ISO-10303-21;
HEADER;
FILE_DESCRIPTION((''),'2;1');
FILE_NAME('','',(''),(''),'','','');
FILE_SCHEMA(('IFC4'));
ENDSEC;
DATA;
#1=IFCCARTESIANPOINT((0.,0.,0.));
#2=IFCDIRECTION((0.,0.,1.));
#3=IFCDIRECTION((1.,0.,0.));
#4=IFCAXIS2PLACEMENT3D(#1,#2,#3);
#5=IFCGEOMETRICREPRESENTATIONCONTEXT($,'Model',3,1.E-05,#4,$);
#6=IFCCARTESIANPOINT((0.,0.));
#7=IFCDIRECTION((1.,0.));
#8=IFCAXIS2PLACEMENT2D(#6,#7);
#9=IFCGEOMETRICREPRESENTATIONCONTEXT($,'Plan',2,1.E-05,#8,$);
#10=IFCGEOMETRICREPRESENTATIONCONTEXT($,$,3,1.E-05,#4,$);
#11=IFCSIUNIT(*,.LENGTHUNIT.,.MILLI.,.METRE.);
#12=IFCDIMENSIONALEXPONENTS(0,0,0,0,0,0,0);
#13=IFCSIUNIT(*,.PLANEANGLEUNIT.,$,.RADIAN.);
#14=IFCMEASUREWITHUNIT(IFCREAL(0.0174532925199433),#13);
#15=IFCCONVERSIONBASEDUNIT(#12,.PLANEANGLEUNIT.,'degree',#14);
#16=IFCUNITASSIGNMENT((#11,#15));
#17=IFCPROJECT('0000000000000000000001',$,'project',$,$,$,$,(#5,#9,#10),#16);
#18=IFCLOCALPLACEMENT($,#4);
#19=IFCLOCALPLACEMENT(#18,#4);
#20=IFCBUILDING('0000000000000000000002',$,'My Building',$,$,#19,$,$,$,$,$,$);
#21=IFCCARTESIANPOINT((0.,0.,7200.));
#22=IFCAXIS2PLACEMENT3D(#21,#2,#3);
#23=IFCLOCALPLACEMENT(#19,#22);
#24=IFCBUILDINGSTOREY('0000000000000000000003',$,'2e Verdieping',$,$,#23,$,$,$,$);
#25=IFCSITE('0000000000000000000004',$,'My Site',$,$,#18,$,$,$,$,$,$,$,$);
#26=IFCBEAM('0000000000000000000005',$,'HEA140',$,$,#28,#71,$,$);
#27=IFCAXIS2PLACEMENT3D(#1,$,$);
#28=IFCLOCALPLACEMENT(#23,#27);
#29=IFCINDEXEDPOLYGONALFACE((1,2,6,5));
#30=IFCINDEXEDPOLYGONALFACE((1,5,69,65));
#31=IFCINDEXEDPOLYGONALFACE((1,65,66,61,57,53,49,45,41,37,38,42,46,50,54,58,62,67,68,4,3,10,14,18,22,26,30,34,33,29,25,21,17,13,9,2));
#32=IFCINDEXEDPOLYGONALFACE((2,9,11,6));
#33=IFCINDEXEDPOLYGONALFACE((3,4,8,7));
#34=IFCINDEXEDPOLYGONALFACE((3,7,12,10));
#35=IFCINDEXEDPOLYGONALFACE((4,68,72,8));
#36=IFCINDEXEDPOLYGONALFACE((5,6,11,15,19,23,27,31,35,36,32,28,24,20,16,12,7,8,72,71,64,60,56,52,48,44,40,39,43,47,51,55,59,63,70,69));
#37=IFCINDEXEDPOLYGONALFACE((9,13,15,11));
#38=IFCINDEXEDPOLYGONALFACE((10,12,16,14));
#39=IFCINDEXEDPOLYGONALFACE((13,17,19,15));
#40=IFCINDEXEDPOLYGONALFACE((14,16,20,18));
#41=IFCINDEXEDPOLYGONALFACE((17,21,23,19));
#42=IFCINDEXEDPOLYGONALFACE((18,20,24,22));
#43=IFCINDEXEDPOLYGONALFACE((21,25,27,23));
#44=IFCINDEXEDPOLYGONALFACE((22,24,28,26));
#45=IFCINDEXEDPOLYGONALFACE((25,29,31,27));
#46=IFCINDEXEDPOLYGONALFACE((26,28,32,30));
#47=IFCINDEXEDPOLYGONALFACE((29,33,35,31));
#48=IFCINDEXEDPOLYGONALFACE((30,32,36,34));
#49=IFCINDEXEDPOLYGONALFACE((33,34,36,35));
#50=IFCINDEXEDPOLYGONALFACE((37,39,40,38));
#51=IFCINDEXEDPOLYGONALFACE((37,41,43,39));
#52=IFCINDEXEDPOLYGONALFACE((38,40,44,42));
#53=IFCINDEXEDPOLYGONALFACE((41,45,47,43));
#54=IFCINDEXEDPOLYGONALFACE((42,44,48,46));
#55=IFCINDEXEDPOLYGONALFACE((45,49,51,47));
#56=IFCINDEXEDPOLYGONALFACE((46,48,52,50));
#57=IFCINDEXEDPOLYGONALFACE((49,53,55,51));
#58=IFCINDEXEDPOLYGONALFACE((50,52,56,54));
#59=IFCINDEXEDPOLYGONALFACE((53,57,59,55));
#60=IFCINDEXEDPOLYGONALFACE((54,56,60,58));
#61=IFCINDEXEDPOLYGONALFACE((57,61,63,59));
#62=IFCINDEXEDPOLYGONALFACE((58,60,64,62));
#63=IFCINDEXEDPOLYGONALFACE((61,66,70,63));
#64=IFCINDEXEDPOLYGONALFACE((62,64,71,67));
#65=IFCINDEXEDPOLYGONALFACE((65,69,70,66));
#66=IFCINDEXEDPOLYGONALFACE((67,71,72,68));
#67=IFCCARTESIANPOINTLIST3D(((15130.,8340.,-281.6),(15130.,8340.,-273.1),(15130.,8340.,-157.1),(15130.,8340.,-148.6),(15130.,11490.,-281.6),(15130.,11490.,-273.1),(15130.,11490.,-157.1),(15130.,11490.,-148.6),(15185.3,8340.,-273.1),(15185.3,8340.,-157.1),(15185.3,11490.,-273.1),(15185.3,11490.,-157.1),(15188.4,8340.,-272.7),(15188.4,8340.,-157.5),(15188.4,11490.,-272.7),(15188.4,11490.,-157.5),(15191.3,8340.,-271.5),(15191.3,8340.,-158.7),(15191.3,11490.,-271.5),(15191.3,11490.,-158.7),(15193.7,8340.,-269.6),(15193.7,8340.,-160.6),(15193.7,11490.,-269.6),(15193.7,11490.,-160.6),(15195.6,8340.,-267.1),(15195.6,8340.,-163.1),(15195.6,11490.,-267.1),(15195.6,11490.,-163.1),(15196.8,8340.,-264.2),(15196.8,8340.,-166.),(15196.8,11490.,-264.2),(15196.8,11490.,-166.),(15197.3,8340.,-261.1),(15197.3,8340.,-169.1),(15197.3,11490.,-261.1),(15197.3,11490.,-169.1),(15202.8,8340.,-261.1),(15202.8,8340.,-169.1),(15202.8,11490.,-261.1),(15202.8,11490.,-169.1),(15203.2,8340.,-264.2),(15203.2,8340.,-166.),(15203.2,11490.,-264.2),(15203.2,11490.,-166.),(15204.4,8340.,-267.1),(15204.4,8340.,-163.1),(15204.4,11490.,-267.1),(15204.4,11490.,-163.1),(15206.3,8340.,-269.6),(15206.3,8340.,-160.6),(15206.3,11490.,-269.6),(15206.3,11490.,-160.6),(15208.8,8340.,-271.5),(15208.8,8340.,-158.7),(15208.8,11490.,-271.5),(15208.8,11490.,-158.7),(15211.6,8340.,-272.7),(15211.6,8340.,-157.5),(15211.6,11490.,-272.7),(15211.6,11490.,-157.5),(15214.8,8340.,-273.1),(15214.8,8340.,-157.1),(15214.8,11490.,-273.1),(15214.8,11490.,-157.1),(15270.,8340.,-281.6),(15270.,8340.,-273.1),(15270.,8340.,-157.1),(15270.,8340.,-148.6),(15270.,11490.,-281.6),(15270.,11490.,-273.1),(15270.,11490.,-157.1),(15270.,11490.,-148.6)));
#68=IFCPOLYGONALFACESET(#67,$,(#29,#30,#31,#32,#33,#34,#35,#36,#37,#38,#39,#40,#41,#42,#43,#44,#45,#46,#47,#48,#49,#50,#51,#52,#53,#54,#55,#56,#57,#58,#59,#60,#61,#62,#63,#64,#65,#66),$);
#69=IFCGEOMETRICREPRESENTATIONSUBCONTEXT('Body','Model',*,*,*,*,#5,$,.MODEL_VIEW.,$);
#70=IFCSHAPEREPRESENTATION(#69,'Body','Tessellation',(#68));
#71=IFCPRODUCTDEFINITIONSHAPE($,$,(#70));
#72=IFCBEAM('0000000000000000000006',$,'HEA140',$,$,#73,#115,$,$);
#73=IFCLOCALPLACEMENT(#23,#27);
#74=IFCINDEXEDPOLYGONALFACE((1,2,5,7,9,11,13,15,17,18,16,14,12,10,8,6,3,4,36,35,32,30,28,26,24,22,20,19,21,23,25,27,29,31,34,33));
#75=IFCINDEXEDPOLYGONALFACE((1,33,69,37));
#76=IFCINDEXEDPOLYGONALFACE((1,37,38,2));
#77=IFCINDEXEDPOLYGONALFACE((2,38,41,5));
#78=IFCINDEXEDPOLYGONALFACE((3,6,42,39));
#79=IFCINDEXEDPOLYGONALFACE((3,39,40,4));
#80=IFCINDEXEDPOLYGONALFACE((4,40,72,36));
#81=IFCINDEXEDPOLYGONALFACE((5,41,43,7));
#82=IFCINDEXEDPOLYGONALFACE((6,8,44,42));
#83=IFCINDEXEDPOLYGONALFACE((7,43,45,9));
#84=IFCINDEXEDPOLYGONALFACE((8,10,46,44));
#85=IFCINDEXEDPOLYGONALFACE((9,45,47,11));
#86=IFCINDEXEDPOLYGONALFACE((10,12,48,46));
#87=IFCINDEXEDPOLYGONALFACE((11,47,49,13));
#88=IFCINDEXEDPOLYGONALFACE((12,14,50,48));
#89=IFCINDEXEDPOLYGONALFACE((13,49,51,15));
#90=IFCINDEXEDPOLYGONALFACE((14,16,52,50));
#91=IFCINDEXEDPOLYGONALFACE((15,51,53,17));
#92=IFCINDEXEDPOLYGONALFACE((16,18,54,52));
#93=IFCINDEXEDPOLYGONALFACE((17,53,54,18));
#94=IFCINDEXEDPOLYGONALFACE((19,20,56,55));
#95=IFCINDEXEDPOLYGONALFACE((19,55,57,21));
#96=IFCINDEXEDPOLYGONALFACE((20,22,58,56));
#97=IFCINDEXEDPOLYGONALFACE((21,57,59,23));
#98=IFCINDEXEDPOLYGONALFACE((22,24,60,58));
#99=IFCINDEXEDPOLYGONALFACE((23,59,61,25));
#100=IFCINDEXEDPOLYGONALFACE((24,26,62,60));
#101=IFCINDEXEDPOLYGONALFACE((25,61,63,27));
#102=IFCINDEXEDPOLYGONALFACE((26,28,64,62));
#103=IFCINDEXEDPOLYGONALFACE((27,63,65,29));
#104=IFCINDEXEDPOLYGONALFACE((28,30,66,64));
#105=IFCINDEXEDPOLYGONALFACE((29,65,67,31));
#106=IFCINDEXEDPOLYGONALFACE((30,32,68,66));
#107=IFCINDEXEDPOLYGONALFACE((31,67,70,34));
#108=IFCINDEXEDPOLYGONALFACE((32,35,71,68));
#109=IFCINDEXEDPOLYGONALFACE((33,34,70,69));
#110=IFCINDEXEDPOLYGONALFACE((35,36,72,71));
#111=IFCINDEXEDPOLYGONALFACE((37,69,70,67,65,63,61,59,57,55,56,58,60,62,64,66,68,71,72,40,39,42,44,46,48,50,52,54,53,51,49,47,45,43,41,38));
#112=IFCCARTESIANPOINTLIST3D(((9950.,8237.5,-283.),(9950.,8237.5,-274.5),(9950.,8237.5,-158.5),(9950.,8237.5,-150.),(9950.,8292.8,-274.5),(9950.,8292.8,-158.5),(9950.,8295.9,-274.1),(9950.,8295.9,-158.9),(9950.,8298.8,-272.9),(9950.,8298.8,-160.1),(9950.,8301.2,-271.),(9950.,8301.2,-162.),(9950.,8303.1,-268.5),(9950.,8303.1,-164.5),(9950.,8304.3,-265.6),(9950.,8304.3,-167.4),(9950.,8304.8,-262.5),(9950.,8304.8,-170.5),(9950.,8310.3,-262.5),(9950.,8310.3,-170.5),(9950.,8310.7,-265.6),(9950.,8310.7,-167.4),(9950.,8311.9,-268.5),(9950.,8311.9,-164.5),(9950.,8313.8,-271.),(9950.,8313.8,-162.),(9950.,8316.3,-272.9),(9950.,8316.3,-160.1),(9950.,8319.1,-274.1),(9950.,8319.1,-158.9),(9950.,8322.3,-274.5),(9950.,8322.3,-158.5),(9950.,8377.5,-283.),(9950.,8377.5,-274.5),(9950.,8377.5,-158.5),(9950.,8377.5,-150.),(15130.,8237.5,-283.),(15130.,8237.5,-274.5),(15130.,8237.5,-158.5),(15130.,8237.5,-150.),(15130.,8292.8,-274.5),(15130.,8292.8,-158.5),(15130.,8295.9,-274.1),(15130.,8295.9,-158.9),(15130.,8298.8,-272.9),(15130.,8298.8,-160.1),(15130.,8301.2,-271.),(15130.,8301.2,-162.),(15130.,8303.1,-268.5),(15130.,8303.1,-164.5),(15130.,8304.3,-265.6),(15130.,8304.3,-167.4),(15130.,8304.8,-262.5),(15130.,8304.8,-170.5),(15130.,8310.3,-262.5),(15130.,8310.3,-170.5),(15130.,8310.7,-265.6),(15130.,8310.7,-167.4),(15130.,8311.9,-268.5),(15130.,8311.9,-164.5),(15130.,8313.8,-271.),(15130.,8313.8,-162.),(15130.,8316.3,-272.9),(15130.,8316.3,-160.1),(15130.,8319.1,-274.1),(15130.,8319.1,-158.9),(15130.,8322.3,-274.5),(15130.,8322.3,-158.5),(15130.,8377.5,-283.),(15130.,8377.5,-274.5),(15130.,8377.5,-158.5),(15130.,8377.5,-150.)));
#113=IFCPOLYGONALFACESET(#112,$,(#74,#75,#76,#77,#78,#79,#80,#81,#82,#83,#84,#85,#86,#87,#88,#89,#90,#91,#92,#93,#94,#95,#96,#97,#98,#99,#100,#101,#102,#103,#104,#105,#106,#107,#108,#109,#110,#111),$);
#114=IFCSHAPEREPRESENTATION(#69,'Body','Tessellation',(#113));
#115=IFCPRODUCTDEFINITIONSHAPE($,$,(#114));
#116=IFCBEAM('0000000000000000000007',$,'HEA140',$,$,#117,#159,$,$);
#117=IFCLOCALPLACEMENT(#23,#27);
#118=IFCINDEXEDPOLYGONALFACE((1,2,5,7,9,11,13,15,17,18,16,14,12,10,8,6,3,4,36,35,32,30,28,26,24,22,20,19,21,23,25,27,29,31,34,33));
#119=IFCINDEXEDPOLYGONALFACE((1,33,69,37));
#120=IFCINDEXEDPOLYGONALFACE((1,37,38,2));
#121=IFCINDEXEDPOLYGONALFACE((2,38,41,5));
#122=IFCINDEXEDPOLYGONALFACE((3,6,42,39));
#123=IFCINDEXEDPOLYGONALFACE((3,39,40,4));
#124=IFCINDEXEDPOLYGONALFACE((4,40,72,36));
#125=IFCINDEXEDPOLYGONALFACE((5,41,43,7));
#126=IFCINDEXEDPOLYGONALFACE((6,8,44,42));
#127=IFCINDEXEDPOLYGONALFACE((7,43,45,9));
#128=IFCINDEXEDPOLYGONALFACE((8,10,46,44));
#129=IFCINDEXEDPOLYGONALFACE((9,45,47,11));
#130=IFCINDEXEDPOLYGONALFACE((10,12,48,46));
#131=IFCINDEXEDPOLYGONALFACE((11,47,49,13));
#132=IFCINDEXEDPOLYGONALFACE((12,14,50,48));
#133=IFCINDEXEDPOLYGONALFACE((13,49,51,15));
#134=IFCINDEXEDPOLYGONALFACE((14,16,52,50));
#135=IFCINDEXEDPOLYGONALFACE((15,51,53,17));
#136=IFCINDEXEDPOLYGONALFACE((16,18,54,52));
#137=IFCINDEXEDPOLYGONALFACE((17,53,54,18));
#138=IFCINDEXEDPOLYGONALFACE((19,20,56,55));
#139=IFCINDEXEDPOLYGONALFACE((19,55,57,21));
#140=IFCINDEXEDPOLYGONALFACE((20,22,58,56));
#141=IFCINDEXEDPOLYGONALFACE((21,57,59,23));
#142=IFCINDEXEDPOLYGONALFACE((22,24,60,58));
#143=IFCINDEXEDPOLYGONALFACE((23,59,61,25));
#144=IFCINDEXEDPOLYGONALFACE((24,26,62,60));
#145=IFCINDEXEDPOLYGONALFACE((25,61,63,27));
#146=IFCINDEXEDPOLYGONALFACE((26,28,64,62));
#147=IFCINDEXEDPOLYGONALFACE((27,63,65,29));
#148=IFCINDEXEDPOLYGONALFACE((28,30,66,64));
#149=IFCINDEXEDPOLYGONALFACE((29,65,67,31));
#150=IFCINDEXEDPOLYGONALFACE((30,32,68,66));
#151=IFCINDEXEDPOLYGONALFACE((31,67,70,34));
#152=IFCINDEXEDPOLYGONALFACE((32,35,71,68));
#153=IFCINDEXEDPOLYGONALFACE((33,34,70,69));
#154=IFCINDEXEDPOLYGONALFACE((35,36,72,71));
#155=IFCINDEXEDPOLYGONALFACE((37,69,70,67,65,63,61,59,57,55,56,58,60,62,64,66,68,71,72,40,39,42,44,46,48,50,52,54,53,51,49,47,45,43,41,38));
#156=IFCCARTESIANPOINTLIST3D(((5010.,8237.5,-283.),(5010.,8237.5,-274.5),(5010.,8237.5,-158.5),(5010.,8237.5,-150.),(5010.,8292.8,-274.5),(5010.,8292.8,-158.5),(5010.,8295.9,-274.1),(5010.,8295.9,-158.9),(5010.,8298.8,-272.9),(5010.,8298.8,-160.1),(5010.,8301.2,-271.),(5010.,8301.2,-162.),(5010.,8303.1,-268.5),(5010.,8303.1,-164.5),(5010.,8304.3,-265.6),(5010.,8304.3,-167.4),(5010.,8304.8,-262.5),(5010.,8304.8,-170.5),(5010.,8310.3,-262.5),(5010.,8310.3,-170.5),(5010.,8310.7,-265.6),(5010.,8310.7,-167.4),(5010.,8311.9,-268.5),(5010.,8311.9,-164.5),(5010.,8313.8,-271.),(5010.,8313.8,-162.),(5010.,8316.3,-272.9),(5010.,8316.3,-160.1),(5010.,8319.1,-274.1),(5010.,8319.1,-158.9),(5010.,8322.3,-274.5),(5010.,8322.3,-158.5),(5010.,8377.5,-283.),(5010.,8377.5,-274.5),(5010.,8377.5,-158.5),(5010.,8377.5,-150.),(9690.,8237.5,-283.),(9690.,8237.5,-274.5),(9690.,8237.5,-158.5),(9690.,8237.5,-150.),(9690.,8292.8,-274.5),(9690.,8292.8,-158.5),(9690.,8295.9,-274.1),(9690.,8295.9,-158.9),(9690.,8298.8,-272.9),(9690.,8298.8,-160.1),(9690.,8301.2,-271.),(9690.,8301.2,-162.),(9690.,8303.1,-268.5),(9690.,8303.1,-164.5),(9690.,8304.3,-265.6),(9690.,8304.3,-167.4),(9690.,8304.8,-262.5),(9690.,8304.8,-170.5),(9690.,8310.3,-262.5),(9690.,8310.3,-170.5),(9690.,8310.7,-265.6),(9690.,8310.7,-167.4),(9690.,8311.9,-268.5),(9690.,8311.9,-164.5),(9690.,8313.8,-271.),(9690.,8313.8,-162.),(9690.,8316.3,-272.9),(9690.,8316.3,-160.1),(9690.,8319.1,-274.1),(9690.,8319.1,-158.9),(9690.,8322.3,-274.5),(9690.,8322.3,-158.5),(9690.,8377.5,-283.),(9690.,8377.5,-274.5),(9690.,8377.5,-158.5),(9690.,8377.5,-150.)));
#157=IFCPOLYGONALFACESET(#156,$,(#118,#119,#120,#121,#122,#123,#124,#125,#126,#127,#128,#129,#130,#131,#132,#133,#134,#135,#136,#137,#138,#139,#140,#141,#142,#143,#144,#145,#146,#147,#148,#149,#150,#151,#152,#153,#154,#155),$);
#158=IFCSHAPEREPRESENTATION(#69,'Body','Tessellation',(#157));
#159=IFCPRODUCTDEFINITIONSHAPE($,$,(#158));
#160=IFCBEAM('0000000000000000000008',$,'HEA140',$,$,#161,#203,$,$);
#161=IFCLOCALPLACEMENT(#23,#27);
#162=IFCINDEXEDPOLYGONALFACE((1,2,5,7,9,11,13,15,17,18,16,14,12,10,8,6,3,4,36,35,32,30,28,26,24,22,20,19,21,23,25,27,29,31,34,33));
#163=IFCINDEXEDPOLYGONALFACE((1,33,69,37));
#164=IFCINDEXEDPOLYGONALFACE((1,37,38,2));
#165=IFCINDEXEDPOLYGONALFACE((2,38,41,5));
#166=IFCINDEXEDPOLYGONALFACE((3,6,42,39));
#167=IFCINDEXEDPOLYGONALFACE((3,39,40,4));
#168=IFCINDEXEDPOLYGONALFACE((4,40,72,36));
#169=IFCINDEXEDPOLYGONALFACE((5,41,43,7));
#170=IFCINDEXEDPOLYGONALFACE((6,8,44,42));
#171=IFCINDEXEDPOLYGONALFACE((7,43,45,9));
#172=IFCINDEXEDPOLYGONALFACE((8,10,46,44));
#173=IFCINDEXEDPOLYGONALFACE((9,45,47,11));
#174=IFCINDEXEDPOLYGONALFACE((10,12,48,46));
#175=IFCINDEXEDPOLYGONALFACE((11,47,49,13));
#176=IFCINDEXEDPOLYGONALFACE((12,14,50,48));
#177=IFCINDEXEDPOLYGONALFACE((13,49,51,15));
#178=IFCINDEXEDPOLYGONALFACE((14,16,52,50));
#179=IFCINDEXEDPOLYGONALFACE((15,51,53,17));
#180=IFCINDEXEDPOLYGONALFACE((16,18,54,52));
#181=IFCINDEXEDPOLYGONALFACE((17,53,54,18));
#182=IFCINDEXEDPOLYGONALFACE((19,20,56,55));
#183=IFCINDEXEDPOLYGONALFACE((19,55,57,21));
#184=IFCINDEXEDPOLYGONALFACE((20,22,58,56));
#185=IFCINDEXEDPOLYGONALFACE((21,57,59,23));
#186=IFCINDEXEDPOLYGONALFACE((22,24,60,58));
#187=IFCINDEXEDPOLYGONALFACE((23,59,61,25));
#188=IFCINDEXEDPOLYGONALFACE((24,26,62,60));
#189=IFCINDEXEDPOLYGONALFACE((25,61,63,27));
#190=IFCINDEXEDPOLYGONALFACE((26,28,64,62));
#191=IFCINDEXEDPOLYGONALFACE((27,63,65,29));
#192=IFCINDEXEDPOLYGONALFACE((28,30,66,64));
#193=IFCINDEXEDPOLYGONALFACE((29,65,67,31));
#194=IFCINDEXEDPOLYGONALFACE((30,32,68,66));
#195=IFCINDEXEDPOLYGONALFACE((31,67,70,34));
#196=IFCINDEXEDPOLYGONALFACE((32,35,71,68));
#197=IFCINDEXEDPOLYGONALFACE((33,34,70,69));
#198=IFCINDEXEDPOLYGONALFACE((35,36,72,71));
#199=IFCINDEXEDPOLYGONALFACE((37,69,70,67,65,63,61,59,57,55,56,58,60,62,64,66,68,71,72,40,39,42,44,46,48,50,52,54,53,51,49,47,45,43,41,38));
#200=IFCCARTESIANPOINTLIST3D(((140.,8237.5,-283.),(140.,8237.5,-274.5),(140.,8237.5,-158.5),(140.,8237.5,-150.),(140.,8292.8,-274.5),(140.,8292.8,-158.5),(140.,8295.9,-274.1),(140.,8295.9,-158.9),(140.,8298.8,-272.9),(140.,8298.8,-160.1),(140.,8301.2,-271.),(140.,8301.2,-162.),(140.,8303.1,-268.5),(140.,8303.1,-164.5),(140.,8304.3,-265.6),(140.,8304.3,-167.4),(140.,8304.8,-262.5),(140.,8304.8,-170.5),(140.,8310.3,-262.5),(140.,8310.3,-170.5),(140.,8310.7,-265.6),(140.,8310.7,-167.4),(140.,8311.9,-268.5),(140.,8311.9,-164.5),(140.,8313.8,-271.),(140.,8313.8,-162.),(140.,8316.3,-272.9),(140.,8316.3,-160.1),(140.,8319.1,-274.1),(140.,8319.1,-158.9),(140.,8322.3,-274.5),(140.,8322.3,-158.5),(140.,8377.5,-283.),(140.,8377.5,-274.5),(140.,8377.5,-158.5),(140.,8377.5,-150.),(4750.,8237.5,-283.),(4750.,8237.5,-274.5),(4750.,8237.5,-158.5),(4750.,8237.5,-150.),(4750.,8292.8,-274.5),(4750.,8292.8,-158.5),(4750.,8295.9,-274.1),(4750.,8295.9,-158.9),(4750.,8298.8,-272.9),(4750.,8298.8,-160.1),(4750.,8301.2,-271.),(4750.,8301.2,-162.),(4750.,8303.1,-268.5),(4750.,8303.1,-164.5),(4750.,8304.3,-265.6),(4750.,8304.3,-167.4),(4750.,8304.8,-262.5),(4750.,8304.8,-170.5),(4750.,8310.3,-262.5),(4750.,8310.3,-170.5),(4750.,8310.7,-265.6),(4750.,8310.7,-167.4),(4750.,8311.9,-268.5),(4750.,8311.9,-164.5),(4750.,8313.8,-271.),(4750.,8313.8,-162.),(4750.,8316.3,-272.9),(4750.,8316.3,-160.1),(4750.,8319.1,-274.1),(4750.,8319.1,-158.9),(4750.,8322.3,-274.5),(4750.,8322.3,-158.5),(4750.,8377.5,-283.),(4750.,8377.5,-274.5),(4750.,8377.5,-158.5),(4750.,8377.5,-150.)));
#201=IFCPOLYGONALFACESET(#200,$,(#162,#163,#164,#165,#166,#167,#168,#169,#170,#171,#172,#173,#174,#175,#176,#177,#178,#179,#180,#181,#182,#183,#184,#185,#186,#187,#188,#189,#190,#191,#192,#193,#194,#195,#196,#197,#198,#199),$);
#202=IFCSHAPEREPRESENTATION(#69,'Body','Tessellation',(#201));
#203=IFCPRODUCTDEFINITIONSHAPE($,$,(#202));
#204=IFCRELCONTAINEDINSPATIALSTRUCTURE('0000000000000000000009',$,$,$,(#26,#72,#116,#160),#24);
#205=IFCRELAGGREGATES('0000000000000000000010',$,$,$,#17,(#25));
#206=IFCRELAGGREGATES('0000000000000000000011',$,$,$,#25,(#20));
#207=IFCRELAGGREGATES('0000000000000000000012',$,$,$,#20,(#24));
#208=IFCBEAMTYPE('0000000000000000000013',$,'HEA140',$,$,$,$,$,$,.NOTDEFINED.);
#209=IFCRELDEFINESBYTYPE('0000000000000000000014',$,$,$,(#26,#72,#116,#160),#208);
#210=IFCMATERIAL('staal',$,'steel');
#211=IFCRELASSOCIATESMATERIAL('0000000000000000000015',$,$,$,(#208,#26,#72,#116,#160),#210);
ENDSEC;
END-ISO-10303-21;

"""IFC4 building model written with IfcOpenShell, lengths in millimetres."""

from ifc_helpers import new_model, entity, si_unit, converted_unit, frame, origin_with_axes, origin_2d_with_axis, place, context, subcontext, project, spatial, i_section, extrude, material, material_profile, profile_set, profile_usage, type_object, element, save


model = new_model("IFC4")

# Units and contexts
model_context = context("Model", 3, precision=1e-05, world=origin_with_axes())
plan_context = context("Plan", 2, precision=1e-05, world=origin_2d_with_axis())
context_of_model = context(None, 3, precision=1e-05, world=origin_with_axes())
body_context = subcontext(model_context, "Body", "Model", "MODEL_VIEW")
ifc_project = project(units=[si_unit("LENGTHUNIT", "METRE", prefix="MILLI"), converted_unit("PLANEANGLEUNIT", "degree", entity("IfcReal", 0.0174532925199433), si_unit("PLANEANGLEUNIT", "RADIAN"), dimensions=[0, 0, 0, 0, 0, 0, 0])], contexts=[model_context, plan_context, context_of_model])

# Site, building, storey
site_placement = place(None, origin_with_axes())
site = spatial("IfcSite", under=ifc_project, at=site_placement, Name="My Site")
building_placement = place(site_placement, origin_with_axes())
building = spatial("IfcBuilding", under=site, at=building_placement, Name="My Building")
storey_placement = place(building_placement, frame((0.0, 0.0, 7200.0), z_axis=(0.0, 0.0, 1.0), x_axis=(1.0, 0.0, 0.0)))
storey = spatial("IfcBuildingStorey", under=building, at=storey_placement, Name="2e Verdieping")

# Beams
ifc_material_1 = material(Name="staal", Category="steel")
ifc_material_profile_1 = material_profile(ifc_material_1, i_section(OverallWidth=140.0, OverallDepth=133.0, WebThickness=5.5, FlangeThickness=8.5, FilletRadius=12.0))
ifc_profile_set_1 = profile_set([ifc_material_profile_1], Name="HEA140")
beam_type_1 = type_object("IfcBeamType", Name="HEA140", PredefinedType="NOTDEFINED", material=ifc_profile_set_1)
ifc_profile_usage_1 = profile_usage(ifc_profile_set_1)
beam_1_placement = place(storey_placement, frame((15200.0, 8340.0, -215.1), z_axis=(0.0, 1.0, 0.0), x_axis=(-1.0, 0.0, 0.0)))
element("IfcBeam", 1, at=beam_1_placement, inside=storey, type_object=beam_type_1, material=ifc_profile_usage_1, Name="HEA140", context=body_context, shape_type="SweptSolid", body=[
    extrude(i_section(OverallWidth=140.0, OverallDepth=133.0, WebThickness=5.5, FlangeThickness=8.5, FilletRadius=12.0), origin_with_axes(), (0.0, 0.0, 1.0), 3150.0),
])
ifc_profile_usage_2 = profile_usage(ifc_profile_set_1)
beam_2_placement = place(storey_placement, frame((15130.0, 8307.5, -216.5), z_axis=(-1.0, 0.0, 0.0), x_axis=(0.0, -1.0, 0.0)))
element("IfcBeam", 2, at=beam_2_placement, inside=storey, type_object=beam_type_1, material=ifc_profile_usage_2, Name="HEA140", context=body_context, shape_type="SweptSolid", body=[
    extrude(i_section(OverallWidth=140.0, OverallDepth=133.0, WebThickness=5.5, FlangeThickness=8.5, FilletRadius=12.0), origin_with_axes(), (0.0, 0.0, 1.0), 5180.0),
])
ifc_profile_usage_3 = profile_usage(ifc_profile_set_1)
beam_3_placement = place(storey_placement, frame((9690.0, 8307.5, -216.5), z_axis=(-1.0, 0.0, 0.0), x_axis=(0.0, -1.0, 0.0)))
element("IfcBeam", 3, at=beam_3_placement, inside=storey, type_object=beam_type_1, material=ifc_profile_usage_3, Name="HEA140", context=body_context, shape_type="SweptSolid", body=[
    extrude(i_section(OverallWidth=140.0, OverallDepth=133.0, WebThickness=5.5, FlangeThickness=8.5, FilletRadius=12.0), origin_with_axes(), (0.0, 0.0, 1.0), 4680.0),
])
ifc_profile_usage_4 = profile_usage(ifc_profile_set_1)
beam_4_placement = place(storey_placement, frame((4750.0, 8307.5, -216.5), z_axis=(-1.0, 0.0, 0.0), x_axis=(0.0, -1.0, 0.0)))
element("IfcBeam", 4, at=beam_4_placement, inside=storey, type_object=beam_type_1, material=ifc_profile_usage_4, Name="HEA140", context=body_context, shape_type="SweptSolid", body=[
    extrude(i_section(OverallWidth=140.0, OverallDepth=133.0, WebThickness=5.5, FlangeThickness=8.5, FilletRadius=12.0), origin_with_axes(), (0.0, 0.0, 1.0), 4610.0),
])

save(model, "model.ifc")
